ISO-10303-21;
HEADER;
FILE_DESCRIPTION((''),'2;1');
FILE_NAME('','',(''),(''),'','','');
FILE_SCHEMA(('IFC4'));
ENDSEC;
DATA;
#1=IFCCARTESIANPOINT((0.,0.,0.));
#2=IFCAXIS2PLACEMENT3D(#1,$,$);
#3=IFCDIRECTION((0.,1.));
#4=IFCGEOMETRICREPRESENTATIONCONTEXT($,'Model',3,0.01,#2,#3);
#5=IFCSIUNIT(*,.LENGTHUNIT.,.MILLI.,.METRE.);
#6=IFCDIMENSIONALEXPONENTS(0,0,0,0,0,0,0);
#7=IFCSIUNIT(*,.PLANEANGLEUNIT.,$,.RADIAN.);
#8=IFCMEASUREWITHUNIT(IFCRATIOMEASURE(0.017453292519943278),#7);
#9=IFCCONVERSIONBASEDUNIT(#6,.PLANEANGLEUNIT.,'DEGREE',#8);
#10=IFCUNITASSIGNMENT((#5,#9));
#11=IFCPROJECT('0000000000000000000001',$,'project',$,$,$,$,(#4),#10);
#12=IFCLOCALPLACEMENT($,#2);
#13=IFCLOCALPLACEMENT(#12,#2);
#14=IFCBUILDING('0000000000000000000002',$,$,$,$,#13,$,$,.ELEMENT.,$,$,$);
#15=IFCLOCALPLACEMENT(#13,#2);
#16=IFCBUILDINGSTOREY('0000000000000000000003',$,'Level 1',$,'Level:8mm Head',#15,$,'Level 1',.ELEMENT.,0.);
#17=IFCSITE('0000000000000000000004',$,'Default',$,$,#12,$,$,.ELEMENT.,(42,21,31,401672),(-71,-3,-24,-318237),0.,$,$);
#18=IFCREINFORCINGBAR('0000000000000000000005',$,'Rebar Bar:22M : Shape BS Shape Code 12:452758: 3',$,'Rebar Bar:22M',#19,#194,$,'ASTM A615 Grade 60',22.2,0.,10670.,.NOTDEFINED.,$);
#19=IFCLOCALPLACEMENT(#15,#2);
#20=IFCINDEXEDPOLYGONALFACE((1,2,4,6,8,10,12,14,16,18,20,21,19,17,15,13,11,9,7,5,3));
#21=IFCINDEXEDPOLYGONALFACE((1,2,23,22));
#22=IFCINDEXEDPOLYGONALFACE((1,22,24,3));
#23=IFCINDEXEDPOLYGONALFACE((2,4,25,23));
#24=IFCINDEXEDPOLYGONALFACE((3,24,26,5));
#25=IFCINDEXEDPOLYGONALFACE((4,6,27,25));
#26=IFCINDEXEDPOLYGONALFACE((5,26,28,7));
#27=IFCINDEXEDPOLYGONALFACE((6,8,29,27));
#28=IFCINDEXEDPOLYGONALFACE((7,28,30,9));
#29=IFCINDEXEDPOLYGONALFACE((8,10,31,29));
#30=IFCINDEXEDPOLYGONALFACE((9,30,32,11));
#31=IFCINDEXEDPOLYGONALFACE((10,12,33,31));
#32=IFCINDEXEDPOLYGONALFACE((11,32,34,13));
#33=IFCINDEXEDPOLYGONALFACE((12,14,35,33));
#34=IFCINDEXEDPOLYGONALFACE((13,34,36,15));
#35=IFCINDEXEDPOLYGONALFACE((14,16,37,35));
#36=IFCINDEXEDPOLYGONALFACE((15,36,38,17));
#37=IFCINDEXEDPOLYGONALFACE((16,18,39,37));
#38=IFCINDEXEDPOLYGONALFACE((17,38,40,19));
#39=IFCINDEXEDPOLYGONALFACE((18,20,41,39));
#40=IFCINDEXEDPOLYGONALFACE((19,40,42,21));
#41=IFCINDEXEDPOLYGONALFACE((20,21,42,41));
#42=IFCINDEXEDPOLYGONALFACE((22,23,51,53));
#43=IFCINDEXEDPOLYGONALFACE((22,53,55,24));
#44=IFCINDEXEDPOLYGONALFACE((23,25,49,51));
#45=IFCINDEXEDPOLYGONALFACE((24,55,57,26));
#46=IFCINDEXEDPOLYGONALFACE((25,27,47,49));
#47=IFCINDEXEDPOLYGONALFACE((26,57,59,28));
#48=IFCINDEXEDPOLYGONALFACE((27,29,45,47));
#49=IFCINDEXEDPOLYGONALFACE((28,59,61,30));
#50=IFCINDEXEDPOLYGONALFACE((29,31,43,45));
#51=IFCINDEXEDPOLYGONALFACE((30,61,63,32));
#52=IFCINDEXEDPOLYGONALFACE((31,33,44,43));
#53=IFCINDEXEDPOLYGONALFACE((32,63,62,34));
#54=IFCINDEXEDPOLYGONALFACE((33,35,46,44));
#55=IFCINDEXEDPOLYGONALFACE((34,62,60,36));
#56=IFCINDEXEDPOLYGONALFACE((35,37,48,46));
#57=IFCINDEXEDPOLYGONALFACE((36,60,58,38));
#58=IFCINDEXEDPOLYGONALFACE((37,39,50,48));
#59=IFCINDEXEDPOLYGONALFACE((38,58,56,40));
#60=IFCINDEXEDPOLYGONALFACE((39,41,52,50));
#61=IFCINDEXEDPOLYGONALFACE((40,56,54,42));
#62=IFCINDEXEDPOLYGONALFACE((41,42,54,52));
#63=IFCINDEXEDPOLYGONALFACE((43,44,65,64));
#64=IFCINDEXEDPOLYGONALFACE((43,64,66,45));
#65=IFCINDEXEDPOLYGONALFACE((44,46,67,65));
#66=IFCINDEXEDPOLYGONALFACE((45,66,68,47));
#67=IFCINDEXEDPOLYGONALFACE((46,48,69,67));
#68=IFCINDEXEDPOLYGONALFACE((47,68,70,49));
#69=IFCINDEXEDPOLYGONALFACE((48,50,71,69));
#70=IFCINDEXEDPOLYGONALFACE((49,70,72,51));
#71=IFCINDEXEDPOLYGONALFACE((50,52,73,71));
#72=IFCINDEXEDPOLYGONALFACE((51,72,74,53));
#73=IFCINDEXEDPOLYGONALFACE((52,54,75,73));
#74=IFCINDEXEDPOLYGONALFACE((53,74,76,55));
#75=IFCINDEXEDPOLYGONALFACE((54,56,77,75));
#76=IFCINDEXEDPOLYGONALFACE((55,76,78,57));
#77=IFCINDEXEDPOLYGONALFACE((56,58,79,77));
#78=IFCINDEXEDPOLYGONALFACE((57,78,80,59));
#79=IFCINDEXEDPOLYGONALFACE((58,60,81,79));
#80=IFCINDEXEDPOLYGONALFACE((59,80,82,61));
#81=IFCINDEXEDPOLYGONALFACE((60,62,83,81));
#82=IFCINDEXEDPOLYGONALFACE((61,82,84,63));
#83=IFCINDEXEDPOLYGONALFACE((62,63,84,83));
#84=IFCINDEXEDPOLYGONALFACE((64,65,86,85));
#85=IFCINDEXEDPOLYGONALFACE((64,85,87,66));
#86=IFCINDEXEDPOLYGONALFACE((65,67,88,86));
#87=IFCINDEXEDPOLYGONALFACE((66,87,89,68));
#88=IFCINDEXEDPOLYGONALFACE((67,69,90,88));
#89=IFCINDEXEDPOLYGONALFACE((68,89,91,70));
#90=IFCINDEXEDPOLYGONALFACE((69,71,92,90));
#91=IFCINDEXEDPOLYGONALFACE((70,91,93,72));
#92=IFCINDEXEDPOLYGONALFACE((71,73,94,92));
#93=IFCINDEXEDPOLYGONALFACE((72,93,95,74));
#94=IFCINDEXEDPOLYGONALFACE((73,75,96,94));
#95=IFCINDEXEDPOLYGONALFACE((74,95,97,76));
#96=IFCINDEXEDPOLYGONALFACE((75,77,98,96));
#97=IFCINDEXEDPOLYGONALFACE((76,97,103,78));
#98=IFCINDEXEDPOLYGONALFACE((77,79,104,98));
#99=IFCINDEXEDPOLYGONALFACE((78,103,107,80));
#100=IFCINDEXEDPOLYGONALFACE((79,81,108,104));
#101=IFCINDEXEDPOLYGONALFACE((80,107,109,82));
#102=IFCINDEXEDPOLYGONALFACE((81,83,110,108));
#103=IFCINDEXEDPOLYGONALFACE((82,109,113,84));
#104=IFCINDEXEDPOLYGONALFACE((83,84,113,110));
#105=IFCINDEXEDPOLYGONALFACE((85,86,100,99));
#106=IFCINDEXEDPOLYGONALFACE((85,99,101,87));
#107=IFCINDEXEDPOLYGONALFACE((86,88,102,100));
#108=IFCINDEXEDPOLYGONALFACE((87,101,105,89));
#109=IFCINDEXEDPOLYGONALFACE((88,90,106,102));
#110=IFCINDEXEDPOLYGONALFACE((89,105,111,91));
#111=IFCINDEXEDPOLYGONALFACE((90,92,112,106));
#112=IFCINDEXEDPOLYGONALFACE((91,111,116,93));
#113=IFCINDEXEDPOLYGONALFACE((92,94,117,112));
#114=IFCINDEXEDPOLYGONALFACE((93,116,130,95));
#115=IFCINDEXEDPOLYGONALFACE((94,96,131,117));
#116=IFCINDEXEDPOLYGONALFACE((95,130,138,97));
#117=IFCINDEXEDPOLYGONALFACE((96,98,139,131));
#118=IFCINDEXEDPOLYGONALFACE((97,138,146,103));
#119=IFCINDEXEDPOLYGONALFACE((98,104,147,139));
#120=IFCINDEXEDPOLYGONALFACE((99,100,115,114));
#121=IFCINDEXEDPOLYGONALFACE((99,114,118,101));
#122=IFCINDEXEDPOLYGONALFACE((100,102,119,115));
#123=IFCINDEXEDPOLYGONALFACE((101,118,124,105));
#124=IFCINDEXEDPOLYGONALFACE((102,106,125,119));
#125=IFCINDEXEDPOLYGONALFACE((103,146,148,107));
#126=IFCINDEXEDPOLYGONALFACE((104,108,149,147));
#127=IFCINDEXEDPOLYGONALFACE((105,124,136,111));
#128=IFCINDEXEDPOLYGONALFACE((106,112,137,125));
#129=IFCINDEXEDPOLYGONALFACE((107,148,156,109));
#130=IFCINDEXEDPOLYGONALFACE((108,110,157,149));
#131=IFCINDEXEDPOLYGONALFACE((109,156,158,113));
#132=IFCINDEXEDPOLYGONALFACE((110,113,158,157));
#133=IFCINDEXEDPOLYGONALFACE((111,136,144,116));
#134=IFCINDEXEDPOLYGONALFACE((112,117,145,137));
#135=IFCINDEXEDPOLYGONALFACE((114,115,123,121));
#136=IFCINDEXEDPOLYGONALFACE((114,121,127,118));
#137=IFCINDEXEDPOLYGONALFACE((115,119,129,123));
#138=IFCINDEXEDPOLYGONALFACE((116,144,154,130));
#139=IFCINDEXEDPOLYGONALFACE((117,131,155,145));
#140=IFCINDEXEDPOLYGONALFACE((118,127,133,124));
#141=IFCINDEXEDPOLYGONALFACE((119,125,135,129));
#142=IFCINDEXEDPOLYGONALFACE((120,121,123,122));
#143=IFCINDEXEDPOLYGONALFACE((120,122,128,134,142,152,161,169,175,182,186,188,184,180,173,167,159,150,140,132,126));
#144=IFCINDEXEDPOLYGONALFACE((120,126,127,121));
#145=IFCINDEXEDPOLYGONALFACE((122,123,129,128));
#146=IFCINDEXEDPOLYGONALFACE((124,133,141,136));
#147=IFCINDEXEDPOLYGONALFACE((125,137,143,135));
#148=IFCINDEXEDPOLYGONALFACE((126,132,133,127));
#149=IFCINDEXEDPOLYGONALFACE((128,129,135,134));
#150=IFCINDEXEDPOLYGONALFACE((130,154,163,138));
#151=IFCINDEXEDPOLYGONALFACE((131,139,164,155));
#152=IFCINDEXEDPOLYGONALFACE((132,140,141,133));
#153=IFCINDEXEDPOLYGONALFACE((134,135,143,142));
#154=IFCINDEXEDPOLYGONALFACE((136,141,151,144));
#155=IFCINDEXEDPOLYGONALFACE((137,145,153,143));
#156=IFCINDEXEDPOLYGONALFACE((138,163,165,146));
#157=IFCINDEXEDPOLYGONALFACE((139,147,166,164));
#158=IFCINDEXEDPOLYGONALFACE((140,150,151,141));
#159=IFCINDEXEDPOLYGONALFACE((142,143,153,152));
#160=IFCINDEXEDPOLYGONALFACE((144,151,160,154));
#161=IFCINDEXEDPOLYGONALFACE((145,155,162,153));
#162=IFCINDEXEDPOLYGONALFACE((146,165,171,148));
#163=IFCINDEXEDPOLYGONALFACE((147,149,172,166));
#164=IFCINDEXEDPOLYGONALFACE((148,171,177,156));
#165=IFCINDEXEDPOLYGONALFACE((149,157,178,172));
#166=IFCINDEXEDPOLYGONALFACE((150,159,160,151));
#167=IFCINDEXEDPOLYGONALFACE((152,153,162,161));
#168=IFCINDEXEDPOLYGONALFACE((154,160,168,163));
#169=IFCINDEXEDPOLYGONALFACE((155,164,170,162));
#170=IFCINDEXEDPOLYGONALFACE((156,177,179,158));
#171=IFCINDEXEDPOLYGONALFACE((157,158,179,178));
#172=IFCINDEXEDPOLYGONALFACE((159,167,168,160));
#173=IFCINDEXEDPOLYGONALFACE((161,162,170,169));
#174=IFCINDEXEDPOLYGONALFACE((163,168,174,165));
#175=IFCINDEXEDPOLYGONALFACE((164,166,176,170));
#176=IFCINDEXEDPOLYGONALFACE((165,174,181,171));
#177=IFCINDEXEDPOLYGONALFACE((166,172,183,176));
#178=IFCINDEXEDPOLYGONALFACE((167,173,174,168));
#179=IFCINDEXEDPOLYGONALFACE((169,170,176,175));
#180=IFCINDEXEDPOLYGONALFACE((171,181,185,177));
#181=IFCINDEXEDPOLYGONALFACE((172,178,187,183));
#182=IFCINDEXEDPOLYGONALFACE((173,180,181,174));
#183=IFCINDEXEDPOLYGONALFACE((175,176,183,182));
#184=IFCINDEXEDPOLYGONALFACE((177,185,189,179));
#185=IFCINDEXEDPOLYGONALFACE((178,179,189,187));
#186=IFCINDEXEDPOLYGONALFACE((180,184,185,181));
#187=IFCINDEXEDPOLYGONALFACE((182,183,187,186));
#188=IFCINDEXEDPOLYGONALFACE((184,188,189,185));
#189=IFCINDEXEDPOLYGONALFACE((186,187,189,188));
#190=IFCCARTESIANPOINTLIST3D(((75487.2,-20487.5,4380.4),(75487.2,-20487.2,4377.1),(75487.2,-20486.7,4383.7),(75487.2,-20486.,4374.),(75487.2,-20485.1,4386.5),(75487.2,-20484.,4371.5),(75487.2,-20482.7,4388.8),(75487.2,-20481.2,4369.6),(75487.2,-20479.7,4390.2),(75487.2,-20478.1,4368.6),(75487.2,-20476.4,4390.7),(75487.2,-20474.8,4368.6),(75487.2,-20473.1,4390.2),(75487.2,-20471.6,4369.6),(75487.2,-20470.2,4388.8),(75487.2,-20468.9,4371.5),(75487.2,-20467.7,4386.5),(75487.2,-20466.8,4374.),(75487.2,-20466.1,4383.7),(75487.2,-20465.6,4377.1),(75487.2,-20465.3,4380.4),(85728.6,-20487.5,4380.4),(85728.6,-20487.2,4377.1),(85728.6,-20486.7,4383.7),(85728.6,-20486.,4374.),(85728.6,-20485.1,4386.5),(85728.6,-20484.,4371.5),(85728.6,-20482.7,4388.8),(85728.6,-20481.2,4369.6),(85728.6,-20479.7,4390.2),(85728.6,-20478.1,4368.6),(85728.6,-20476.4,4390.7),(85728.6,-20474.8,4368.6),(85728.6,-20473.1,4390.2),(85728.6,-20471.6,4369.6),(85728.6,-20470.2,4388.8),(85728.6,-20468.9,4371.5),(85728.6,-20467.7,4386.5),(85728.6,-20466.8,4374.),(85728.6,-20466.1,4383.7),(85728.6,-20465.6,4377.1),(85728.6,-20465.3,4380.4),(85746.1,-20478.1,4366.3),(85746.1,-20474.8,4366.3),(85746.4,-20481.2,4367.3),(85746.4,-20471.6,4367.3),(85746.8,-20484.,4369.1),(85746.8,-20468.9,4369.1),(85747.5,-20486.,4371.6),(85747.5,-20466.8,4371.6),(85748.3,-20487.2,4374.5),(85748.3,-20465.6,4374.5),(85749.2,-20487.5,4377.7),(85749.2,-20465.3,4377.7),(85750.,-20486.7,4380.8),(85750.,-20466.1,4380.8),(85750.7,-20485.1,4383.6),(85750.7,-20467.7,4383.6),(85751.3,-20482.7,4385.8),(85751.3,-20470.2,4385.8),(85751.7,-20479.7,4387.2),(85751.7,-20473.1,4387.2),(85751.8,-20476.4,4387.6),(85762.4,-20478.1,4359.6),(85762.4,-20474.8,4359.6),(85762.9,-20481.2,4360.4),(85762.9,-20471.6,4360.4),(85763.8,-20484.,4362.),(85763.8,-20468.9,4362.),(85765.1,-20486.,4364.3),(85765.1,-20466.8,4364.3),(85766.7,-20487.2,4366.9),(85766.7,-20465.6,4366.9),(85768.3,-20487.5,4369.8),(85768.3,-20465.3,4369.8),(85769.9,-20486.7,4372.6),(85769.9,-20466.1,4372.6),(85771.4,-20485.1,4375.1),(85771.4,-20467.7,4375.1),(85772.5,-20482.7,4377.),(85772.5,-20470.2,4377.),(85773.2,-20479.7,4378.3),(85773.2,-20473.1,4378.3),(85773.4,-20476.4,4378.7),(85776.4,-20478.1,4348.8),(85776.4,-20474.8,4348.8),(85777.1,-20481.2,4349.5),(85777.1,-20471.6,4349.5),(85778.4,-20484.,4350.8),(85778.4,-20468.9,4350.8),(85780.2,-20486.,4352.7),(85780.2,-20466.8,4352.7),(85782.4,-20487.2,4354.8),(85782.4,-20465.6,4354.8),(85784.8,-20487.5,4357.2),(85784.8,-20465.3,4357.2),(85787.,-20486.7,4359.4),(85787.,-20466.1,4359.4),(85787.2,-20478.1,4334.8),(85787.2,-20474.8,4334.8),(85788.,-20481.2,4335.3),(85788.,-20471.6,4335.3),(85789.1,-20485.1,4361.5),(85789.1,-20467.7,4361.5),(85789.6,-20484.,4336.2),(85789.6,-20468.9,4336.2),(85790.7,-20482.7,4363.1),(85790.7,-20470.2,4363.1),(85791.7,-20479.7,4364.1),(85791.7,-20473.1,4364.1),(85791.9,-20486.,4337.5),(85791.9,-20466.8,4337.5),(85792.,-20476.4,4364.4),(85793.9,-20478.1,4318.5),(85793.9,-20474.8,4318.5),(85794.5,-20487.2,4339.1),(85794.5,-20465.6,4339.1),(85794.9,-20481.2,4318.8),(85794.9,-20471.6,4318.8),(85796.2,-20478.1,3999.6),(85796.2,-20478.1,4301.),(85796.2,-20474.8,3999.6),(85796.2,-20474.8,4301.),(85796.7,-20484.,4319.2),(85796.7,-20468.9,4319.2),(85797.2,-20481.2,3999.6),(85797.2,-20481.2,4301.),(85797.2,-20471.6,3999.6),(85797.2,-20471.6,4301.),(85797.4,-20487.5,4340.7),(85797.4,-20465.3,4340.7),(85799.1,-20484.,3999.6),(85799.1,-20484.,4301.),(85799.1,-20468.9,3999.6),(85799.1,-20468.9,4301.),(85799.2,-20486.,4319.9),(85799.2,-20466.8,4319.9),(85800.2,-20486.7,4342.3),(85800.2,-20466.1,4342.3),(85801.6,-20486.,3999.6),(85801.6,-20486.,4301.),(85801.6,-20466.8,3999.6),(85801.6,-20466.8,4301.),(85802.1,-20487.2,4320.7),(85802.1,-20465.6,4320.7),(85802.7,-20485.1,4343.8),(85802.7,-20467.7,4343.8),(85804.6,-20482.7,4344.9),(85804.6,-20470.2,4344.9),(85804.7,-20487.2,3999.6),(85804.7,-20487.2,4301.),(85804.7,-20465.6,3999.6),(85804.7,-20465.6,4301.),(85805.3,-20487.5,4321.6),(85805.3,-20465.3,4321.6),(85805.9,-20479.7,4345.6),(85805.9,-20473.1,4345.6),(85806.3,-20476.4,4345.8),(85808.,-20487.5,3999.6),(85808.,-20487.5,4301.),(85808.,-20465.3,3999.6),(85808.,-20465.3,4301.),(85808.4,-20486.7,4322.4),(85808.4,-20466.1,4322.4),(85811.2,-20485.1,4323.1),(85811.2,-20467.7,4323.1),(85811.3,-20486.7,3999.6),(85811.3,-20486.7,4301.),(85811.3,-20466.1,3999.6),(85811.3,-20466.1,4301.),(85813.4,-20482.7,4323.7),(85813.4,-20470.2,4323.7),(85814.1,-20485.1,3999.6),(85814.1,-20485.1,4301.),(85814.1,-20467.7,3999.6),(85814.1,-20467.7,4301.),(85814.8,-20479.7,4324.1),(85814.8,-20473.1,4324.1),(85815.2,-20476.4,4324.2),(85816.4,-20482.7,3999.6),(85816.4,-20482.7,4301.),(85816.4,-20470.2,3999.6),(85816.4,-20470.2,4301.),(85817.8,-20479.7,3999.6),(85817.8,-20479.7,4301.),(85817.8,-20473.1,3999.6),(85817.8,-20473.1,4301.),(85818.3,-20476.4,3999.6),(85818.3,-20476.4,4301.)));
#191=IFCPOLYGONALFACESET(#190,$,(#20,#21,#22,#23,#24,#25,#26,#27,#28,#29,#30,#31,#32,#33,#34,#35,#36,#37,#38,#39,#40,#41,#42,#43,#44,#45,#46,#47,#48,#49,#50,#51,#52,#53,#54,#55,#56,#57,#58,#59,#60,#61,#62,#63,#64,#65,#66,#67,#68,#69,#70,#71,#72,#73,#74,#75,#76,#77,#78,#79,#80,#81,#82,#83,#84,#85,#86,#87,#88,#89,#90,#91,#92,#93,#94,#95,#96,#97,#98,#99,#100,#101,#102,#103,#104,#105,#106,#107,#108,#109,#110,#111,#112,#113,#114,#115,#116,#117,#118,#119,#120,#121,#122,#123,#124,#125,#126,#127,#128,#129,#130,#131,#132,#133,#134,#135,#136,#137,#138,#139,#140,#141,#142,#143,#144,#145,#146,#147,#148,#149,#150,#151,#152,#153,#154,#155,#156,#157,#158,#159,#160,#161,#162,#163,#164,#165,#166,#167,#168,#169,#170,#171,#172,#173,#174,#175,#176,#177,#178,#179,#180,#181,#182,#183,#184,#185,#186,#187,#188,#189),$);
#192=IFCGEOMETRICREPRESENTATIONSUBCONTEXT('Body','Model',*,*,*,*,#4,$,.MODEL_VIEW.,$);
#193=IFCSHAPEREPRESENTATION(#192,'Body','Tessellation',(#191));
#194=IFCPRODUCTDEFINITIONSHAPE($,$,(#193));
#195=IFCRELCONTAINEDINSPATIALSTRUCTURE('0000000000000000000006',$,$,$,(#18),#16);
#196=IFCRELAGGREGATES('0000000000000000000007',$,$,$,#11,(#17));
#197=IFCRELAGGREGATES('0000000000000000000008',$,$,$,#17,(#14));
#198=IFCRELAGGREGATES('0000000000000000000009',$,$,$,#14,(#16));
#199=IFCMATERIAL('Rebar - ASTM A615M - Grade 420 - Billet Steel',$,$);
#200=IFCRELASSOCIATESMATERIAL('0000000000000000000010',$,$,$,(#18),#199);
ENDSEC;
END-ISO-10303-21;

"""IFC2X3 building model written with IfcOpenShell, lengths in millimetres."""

from ifc_helpers import new_model, entity, si_unit, converted_unit, direction, origin, place, context, subcontext, project, spatial, material, element, save


model = new_model("IFC2X3")

# Units and contexts
model_context = context("Model", 3, precision=0.01, world=origin(), true_north=direction((0.0, 1.0)))
body_context = subcontext(model_context, "Body", "Model", "MODEL_VIEW")
ifc_project = project(units=[si_unit("LENGTHUNIT", "METRE", prefix="MILLI"), converted_unit("PLANEANGLEUNIT", "DEGREE", entity("IfcRatioMeasure", 0.017453292519943278), si_unit("PLANEANGLEUNIT", "RADIAN"), dimensions=[0, 0, 0, 0, 0, 0, 0])], contexts=[model_context])

# Site, building, storey
site_placement = place(None, origin())
site = spatial("IfcSite", under=ifc_project, at=site_placement, Name="Default", CompositionType="ELEMENT", RefLatitude=(42, 21, 31, 401672), RefLongitude=(-71, -3, -24, -318237), RefElevation=0.0)
building_placement = place(site_placement, origin())
building = spatial("IfcBuilding", under=site, at=building_placement, CompositionType="ELEMENT")
storey_placement = place(building_placement, origin())
storey = spatial("IfcBuildingStorey", under=building, at=storey_placement, Name="Level 1", ObjectType="Level:8mm Head", LongName="Level 1", CompositionType="ELEMENT", Elevation=0.0)

# Reinforcing bar
ifc_material = material(Name="Rebar - ASTM A615M - Grade 420 - Billet Steel")
reinforcing_bar_1_placement = place(storey_placement, origin())
element("IfcReinforcingBar", 1, at=reinforcing_bar_1_placement, inside=storey, material=ifc_material, Name="Rebar Bar:22M : Shape BS Shape Code 12:452758: 3", SteelGrade="ASTM A615 Grade 60", ObjectType="Rebar Bar:22M", BarLength=10670.0, BarRole="NOTDEFINED", CrossSectionArea=0.0, NominalDiameter=22.2, context=body_context, shape_type="AdvancedSweptSolid", body=[
    entity("IfcSweptDiskSolid", entity("IfcCompositeCurve", [entity("IfcCompositeCurveSegment", "CONTINUOUS", True, entity("IfcPolyline", [entity("IfcCartesianPoint", [75487.2, -20476.4, 4379.6]), entity("IfcCartesianPoint", [85728.6, -20476.4, 4379.6])])), entity("IfcCompositeCurveSegment", "CONTINUOUS", True, entity("IfcTrimmedCurve", entity("IfcCircle", entity("IfcAxis2Placement3D", entity("IfcCartesianPoint", [85728.6, -20476.4, 4301.0]), entity("IfcDirection", [0.0, 1.0, 0.0]), entity("IfcDirection", [1.0, 0.0, 0.0])), 78.6), [entity("IfcParameterValue", 270.0)], [entity("IfcParameterValue", 360.0)], True, "PARAMETER")), entity("IfcCompositeCurveSegment", "CONTINUOUS", True, entity("IfcPolyline", [entity("IfcCartesianPoint", [85807.2, -20476.4, 4301.0]), entity("IfcCartesianPoint", [85807.2, -20476.4, 3999.6])]))], False), 11.1, None, 0.0, 92.0),
])

save(model, "model.ifc")
